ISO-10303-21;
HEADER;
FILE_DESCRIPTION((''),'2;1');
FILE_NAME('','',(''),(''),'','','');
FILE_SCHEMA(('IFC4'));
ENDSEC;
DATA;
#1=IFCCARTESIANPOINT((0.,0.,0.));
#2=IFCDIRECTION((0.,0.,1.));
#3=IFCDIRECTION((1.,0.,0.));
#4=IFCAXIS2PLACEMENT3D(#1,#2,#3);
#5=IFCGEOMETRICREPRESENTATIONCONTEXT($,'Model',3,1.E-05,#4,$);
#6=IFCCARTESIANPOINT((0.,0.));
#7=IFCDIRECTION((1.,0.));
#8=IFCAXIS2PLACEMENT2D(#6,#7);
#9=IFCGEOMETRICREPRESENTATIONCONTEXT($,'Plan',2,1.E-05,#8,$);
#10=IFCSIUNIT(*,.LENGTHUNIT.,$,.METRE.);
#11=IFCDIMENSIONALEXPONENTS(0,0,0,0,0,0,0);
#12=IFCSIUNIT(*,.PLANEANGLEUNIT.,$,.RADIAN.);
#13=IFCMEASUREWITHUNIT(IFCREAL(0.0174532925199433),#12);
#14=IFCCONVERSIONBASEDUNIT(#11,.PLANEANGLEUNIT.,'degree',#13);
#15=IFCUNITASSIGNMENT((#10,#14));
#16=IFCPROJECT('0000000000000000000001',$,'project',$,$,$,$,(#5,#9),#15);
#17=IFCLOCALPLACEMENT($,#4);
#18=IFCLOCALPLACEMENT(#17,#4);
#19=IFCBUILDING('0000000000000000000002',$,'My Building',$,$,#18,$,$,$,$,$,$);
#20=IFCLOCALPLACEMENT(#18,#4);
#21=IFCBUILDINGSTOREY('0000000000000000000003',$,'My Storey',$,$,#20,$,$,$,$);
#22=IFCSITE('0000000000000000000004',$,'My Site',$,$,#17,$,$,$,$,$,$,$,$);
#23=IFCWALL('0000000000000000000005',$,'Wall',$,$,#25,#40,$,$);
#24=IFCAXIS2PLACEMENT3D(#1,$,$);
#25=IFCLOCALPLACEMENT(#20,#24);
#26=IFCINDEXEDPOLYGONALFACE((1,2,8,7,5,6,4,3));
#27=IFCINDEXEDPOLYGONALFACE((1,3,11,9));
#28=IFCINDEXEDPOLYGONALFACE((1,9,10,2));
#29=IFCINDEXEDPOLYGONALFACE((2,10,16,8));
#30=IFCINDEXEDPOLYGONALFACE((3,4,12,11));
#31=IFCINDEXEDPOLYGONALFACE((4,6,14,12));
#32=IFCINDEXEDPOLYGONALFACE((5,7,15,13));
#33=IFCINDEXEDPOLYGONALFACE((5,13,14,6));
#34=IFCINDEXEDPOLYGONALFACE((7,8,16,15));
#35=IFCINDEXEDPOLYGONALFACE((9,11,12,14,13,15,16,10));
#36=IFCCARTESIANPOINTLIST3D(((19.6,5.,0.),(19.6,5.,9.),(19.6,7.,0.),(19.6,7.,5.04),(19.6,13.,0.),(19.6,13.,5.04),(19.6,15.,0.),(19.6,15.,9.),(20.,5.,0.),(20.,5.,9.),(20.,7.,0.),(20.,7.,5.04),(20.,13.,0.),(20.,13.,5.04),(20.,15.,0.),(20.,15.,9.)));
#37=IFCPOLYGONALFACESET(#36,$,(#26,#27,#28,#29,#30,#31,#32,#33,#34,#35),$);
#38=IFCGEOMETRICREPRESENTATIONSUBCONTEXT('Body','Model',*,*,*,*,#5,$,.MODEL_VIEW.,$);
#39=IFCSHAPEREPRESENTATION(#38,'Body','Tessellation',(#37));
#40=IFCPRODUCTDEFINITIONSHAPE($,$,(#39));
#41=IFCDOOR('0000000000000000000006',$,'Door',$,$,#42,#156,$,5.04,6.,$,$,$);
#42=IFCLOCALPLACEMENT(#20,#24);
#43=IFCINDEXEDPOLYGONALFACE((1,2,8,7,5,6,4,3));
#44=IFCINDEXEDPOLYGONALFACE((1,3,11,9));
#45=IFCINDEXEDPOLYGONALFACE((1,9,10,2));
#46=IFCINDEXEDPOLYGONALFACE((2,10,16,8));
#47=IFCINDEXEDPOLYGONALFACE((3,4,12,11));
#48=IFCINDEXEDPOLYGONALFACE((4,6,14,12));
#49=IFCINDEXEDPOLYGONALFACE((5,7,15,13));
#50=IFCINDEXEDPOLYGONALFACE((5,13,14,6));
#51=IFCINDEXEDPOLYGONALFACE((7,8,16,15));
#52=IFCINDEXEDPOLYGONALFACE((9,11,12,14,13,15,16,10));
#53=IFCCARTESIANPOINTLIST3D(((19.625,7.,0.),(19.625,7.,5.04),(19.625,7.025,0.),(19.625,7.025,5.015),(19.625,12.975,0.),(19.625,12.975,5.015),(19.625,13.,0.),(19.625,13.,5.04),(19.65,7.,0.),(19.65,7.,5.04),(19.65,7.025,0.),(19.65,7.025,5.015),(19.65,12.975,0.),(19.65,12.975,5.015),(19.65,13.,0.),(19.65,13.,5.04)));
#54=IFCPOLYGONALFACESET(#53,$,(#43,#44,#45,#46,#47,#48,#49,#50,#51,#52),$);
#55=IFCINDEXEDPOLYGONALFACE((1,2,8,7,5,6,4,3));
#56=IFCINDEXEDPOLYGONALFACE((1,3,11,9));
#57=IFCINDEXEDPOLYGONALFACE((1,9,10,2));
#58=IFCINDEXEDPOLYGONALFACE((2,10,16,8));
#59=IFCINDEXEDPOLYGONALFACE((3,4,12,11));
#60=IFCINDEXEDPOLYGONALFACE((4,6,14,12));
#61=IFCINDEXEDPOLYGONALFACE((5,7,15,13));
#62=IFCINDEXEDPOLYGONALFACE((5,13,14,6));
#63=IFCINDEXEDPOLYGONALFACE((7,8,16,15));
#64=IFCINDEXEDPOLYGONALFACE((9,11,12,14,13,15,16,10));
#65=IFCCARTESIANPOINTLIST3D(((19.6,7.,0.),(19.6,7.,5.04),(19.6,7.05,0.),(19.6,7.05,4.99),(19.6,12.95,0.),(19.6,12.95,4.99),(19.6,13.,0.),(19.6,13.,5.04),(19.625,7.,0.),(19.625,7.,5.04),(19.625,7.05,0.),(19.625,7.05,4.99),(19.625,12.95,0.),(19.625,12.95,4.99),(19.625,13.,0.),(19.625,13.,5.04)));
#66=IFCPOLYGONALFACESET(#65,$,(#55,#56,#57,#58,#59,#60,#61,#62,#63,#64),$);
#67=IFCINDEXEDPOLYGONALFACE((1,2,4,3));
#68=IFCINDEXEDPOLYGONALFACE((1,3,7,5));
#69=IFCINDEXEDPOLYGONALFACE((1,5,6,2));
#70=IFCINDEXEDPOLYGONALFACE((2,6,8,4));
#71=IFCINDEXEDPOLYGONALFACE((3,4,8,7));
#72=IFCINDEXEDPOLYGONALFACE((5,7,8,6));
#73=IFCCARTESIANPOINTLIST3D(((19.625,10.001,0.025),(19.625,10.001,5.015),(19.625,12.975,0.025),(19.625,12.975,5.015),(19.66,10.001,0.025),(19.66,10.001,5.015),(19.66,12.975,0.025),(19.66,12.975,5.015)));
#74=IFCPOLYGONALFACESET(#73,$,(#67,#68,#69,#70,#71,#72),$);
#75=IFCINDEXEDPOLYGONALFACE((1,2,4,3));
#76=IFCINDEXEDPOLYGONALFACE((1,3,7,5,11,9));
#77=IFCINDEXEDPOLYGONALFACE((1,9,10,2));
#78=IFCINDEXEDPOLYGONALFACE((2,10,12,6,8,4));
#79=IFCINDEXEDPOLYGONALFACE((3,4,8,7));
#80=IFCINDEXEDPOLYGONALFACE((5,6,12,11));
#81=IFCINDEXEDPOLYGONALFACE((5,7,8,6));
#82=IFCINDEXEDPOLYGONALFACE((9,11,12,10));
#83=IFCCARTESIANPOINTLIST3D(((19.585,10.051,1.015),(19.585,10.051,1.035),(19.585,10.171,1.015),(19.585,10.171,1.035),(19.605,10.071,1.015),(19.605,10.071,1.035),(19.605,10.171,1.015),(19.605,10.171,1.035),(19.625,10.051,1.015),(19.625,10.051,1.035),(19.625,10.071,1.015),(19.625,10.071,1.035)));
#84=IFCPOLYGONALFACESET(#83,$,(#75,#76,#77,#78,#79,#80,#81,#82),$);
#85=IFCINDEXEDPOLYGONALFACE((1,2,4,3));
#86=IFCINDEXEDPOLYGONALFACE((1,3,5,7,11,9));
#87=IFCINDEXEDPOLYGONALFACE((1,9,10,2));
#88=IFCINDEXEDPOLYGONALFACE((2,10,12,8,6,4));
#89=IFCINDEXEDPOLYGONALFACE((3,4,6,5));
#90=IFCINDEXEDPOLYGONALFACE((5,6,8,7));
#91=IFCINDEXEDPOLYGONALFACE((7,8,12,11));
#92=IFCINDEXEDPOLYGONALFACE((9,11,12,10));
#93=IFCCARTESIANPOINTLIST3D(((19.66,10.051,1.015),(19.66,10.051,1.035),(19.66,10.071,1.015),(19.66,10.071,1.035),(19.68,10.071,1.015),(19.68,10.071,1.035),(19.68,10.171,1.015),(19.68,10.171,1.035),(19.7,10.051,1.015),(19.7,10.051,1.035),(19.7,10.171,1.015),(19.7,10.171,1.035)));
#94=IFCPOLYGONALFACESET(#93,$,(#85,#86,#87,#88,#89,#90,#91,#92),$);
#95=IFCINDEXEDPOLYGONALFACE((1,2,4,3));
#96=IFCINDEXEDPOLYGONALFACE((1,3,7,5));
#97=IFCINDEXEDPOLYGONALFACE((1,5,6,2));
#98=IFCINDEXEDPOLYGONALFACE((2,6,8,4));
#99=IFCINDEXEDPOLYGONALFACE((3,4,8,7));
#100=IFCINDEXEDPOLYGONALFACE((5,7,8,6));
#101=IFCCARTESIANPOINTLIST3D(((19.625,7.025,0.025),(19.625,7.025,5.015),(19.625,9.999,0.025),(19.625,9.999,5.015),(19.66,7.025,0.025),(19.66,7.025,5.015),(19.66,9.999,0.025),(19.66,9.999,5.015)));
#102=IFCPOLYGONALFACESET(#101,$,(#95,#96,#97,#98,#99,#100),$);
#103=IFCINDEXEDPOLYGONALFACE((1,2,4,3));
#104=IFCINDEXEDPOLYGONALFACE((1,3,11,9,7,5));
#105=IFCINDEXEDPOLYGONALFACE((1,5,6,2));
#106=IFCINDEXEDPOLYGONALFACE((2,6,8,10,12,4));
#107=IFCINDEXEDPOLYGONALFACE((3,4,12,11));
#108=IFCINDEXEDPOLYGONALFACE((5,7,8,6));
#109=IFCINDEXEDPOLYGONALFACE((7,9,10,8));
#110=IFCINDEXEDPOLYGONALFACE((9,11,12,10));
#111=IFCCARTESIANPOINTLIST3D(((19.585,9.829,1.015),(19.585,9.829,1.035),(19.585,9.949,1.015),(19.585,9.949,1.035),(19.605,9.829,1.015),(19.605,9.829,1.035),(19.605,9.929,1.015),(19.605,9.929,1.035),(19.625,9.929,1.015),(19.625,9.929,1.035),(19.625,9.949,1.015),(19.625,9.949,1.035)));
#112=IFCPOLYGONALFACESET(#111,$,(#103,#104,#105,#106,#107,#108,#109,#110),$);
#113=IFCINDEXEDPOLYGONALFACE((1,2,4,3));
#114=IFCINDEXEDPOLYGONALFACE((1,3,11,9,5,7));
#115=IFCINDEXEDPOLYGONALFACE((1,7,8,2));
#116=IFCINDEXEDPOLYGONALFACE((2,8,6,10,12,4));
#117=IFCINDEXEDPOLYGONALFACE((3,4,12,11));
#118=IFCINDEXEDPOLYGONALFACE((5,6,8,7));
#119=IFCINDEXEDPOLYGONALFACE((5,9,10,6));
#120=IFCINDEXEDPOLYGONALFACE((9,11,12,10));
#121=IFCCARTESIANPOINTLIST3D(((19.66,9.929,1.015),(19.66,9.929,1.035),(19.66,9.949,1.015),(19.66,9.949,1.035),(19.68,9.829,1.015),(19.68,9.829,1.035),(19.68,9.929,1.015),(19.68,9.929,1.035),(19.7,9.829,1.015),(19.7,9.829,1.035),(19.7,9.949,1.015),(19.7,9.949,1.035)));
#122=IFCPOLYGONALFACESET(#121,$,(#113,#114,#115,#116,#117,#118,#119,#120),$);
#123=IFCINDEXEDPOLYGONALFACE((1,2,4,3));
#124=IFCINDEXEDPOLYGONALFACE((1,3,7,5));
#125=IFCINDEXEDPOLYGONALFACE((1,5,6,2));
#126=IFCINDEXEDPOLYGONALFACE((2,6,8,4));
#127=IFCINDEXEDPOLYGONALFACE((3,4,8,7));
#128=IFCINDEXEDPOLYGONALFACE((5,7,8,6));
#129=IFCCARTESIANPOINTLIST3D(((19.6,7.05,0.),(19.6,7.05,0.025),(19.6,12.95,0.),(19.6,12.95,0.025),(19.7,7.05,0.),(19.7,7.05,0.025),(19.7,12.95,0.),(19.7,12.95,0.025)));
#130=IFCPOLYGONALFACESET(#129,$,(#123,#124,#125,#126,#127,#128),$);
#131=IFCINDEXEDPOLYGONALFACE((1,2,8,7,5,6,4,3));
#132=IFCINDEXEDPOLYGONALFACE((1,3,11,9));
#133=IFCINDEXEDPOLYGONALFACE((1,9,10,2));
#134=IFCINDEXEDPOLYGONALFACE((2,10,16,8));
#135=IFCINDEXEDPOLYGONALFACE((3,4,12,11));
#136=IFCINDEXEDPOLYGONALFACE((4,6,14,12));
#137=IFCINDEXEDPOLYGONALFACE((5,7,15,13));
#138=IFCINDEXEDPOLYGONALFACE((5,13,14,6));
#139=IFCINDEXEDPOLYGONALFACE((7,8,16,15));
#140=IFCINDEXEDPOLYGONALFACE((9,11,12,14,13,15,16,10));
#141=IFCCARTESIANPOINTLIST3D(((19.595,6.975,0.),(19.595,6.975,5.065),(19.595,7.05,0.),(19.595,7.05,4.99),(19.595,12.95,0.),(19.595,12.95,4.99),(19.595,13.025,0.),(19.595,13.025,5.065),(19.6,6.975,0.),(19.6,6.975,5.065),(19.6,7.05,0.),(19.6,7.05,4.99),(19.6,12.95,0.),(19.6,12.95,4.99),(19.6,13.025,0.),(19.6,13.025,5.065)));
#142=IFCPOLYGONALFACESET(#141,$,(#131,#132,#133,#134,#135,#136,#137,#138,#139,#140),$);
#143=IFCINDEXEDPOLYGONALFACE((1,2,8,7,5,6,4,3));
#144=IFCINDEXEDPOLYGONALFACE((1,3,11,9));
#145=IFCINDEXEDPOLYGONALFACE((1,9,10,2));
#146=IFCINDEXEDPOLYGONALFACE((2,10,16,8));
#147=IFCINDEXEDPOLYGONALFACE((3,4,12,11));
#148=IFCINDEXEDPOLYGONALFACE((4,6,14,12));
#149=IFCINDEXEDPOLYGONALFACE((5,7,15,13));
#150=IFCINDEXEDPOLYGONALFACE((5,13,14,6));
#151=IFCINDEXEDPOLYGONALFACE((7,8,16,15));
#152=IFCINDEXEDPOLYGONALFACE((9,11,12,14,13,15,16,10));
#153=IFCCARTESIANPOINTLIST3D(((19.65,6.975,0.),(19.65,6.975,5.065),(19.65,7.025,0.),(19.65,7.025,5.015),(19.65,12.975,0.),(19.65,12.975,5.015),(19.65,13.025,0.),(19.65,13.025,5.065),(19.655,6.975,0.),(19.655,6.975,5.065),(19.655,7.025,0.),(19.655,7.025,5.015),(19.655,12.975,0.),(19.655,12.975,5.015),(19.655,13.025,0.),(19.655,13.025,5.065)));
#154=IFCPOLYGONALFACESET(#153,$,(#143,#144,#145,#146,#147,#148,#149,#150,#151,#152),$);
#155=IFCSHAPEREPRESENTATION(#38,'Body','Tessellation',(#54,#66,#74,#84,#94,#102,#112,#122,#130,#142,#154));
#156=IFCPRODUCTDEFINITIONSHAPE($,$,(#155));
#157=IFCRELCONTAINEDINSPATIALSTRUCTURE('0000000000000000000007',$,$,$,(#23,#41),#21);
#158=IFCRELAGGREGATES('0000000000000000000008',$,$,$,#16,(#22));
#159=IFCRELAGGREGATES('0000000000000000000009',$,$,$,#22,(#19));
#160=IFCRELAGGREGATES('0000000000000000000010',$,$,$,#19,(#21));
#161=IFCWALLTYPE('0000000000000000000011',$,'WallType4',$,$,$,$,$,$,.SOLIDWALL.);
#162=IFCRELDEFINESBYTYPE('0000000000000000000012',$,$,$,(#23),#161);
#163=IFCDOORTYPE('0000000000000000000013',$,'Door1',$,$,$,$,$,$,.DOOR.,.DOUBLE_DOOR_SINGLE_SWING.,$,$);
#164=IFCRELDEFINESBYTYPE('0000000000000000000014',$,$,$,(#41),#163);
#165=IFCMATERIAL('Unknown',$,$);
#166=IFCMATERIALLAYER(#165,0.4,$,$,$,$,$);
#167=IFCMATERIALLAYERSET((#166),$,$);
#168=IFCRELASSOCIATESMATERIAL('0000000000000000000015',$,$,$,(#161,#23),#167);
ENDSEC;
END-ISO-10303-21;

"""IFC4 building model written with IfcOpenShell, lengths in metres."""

from ifc_helpers import new_model, entity, si_unit, converted_unit, frame, origin_with_axes, origin_2d_with_axis, place, context, subcontext, project, spatial, line, indexed_curve, outline, extrude, shape, source, transform, mapped, material, layer, layer_set, layer_usage, type_object, type_shapes, element, fill, save


model = new_model("IFC4")

# Units and contexts
model_context = context("Model", 3, precision=1e-05, world=origin_with_axes())
plan_context = context("Plan", 2, precision=1e-05, world=origin_2d_with_axis())
body_context_1 = subcontext(model_context, "Body", "Model", "MODEL_VIEW")
body_context_2 = subcontext(plan_context, "Body", "Plan", "PLAN_VIEW")
ifc_project = project(units=[si_unit("LENGTHUNIT", "METRE"), converted_unit("PLANEANGLEUNIT", "degree", entity("IfcReal", 0.0174532925199433), si_unit("PLANEANGLEUNIT", "RADIAN"), dimensions=[0, 0, 0, 0, 0, 0, 0])], contexts=[model_context, plan_context])

# Site, building, storey
site_placement = place(None, origin_with_axes())
site = spatial("IfcSite", under=ifc_project, at=site_placement, Name="My Site")
building_placement = place(site_placement, origin_with_axes())
building = spatial("IfcBuilding", under=site, at=building_placement, Name="My Building")
storey_placement = place(building_placement, origin_with_axes())
storey = spatial("IfcBuildingStorey", under=building, at=storey_placement, Name="My Storey")

# Shared definitions
ifc_material = material(Name="Unknown")

# Wall, opening, door
ifc_layer_1 = layer(ifc_material, 0.4)
ifc_layer_set_1 = layer_set([ifc_layer_1])
wall_type_1 = type_object("IfcWallType", Name="WallType4", PredefinedType="SOLIDWALL", material=ifc_layer_set_1)
ifc_layer_usage_1 = layer_usage(ifc_layer_set_1, "AXIS2", "POSITIVE", 0.0)
wall_1_placement = place(storey_placement, frame((19.6, 15.0, 0.0), z_axis=(0.0, 0.0, 1.0), x_axis=(0.0, -1.0, 0.0)))
wall_1 = element("IfcWall", 1, at=wall_1_placement, inside=storey, type_object=wall_type_1, material=ifc_layer_usage_1, Name="Wall", context=body_context_1, shape_type="SweptSolid", body=[
    extrude(outline(indexed_curve([(0.0, 0.0), (0.0, 0.4), (10.0, 0.4), (10.0, 0.0), (0.0, 0.0)], self_intersect=False)), origin_with_axes(), (0.0, 0.0, 1.0), 9.0),
])
shared_shape_1 = source(origin_with_axes(), body_context_1, "Body", "SweptSolid", [
    extrude(outline(indexed_curve([(0.0, 0.0), (6.0, 0.0), (6.0, 5.04), (0.0, 5.04)], segments=[line(1, 2, 3, 4, 1)])), frame((0.0, -0.1, 0.0), z_axis=(0.0, -1.0, 0.0), x_axis=(1.0, 0.0, 0.0)), (0.0, 0.0, -1.0), 0.6),
])
opening_1_placement = place(wall_1_placement, frame((2.0, 0.0, 0.0), z_axis=(0.0, 0.0, 1.0), x_axis=(1.0, 0.0, 0.0)))
opening_1 = element("IfcOpeningElement", 2, at=opening_1_placement, cuts=wall_1, PredefinedType="OPENING", context=body_context_1, shape_type="MappedRepresentation", body=[
    mapped(shared_shape_1, transform((0.0, 0.0, 0.0), x_axis=(1.0, 0.0, 0.0), y_axis=(0.0, 1.0, 0.0), z_axis=(0.0, 0.0, 1.0), scale=1.0)),
])
door_type_1 = type_object("IfcDoorType", Name="Door1", OperationType="DOUBLE_DOOR_SINGLE_SWING", PredefinedType="DOOR")
shared_shape_2 = source(origin_with_axes(), body_context_1, "Body", "SweptSolid", [
    extrude(outline(indexed_curve([(0.0, 0.0), (0.0, 5.04), (6.0, 5.04), (6.0, 0.0), (5.975, 0.0), (5.975, 5.015), (0.025, 5.015), (0.025, 0.0)], segments=[line(1, 2, 3, 4, 5, 6, 7, 8, 1)])), frame((0.0, 0.025, 0.0), z_axis=(0.0, -1.0, 0.0), x_axis=(1.0, 0.0, 0.0)), (0.0, 0.0, -1.0), 0.025),
    extrude(outline(indexed_curve([(0.0, 0.0), (0.0, 5.04), (6.0, 5.04), (6.0, 0.0), (5.95, 0.0), (5.95, 4.99), (0.05, 4.99), (0.05, 0.0)], segments=[line(1, 2, 3, 4, 5, 6, 7, 8, 1)])), frame((0.0, 0.0, 0.0), z_axis=(0.0, -1.0, 0.0), x_axis=(1.0, 0.0, 0.0)), (0.0, 0.0, -1.0), 0.025),
    extrude(outline(indexed_curve([(0.0, 0.0), (2.974, 0.0), (2.974, 0.035), (0.0, 0.035)], segments=[line(1, 2, 3, 4, 1)])), frame((0.025, 0.025, 0.025), z_axis=(0.0, 0.0, 1.0), x_axis=(1.0, 0.0, 0.0)), (0.0, 0.0, 1.0), 4.99),
    extrude(outline(indexed_curve([(0.0, 0.0), (0.0, -0.04), (-0.12, -0.04), (-0.12, -0.02), (-0.02, -0.02), (-0.02, 0.0)], segments=[line(1, 2, 3, 4, 5, 6, 1)])), frame((2.949, 0.025, 1.015), z_axis=(0.0, 0.0, 1.0), x_axis=(1.0, 0.0, 0.0)), (0.0, 0.0, 1.0), 0.02),
    extrude(outline(indexed_curve([(0.0, 0.0), (0.0, 0.04), (-0.12, 0.04), (-0.12, 0.02), (-0.02, 0.02), (-0.02, 0.0)], segments=[line(1, 2, 3, 4, 5, 6, 1)])), frame((2.949, 0.06, 1.015), z_axis=(0.0, 0.0, 1.0), x_axis=(1.0, 0.0, 0.0)), (0.0, 0.0, 1.0), 0.02),
    extrude(outline(indexed_curve([(0.0, 0.0), (-2.974, 0.0), (-2.974, 0.035), (0.0, 0.035)], segments=[line(1, 2, 3, 4, 1)])), frame((5.975, 0.025, 0.025), z_axis=(0.0, 0.0, 1.0), x_axis=(1.0, 0.0, 0.0)), (0.0, 0.0, 1.0), 4.99),
    extrude(outline(indexed_curve([(0.0, 0.0), (0.0, -0.04), (0.12, -0.04), (0.12, -0.02), (0.02, -0.02), (0.02, 0.0)], segments=[line(1, 2, 3, 4, 5, 6, 1)])), frame((3.051, 0.025, 1.015), z_axis=(0.0, 0.0, 1.0), x_axis=(1.0, 0.0, 0.0)), (0.0, 0.0, 1.0), 0.02),
    extrude(outline(indexed_curve([(0.0, 0.0), (0.0, 0.04), (0.12, 0.04), (0.12, 0.02), (0.02, 0.02), (0.02, 0.0)], segments=[line(1, 2, 3, 4, 5, 6, 1)])), frame((3.051, 0.06, 1.015), z_axis=(0.0, 0.0, 1.0), x_axis=(1.0, 0.0, 0.0)), (0.0, 0.0, 1.0), 0.02),
    extrude(outline(indexed_curve([(0.0, 0.0), (5.9, 0.0), (5.9, 0.1), (0.0, 0.1)], segments=[line(1, 2, 3, 4, 1)])), frame((0.05, 0.0, 0.0), z_axis=(0.0, 0.0, 1.0), x_axis=(1.0, 0.0, 0.0)), (0.0, 0.0, 1.0), 0.025),
    extrude(outline(indexed_curve([(0.0, 0.0), (0.0, 5.065), (6.05, 5.065), (6.05, 0.0), (5.975, 0.0), (5.975, 4.99), (0.075, 4.99), (0.075, 0.0)], segments=[line(1, 2, 3, 4, 5, 6, 7, 8, 1)])), frame((-0.025, -0.005, 0.0), z_axis=(0.0, -1.0, 0.0), x_axis=(1.0, 0.0, 0.0)), (0.0, 0.0, -1.0), 0.005),
    extrude(outline(indexed_curve([(0.0, 0.0), (0.0, 5.065), (6.05, 5.065), (6.05, 0.0), (6.0, 0.0), (6.0, 5.015), (0.05, 5.015), (0.05, 0.0)], segments=[line(1, 2, 3, 4, 5, 6, 7, 8, 1)])), frame((-0.025, 0.05, 0.0), z_axis=(0.0, -1.0, 0.0), x_axis=(1.0, 0.0, 0.0)), (0.0, 0.0, -1.0), 0.005),
])
shared_shape_3 = source(origin_with_axes(), body_context_2, "Body", "Curve2D", [
    entity("IfcIndexedPolyCurve", entity("IfcCartesianPointList2D", [[0.0, 0.0], [0.0, 0.05], [0.025, 0.05], [0.025, 0.025], [0.05, 0.025], [0.05, 0.0]]), [entity("IfcLineIndex", [1, 2, 3, 4, 5, 6, 1])]),
    entity("IfcIndexedPolyCurve", entity("IfcCartesianPointList2D", [[6.0, 0.0], [6.0, 0.05], [5.975, 0.05], [5.975, 0.025], [5.95, 0.025], [5.95, 0.0]]), [entity("IfcLineIndex", [1, 2, 3, 4, 5, 6, 1])]),
    entity("IfcTrimmedCurve", entity("IfcEllipse", entity("IfcAxis2Placement2D", entity("IfcCartesianPoint", [0.06, 0.05]), entity("IfcDirection", [1.0, 0.0])), 2.94, 2.975), [entity("IfcCartesianPoint", [3.0, 0.05])], [entity("IfcCartesianPoint", [0.06, 3.025])], True, "CARTESIAN"),
    entity("IfcIndexedPolyCurve", entity("IfcCartesianPointList2D", [[0.025, 0.05], [0.06, 0.05], [0.06, 3.025], [0.025, 3.025]]), [entity("IfcLineIndex", [1, 2, 3, 4, 1])]),
    entity("IfcTrimmedCurve", entity("IfcEllipse", entity("IfcAxis2Placement2D", entity("IfcCartesianPoint", [5.94, 0.05]), entity("IfcDirection", [1.0, 0.0])), 2.94, 2.975), [entity("IfcCartesianPoint", [5.94, 3.025])], [entity("IfcCartesianPoint", [3.0, 0.05])], True, "CARTESIAN"),
    entity("IfcIndexedPolyCurve", entity("IfcCartesianPointList2D", [[5.975, 0.05], [5.94, 0.05], [5.94, 3.025], [5.975, 3.025]]), [entity("IfcLineIndex", [1, 2, 3, 4, 1])]),
])
type_shapes(door_type_1, [shared_shape_2, shared_shape_3])
door_1_placement = place(opening_1_placement, frame((0.0, 0.0, 0.0), z_axis=(0.0, 0.0, 1.0), x_axis=(1.0, 0.0, 0.0)))
door_1 = element("IfcDoor", 3, at=door_1_placement, inside=storey, type_object=door_type_1, Name="Door", OverallHeight=5.04, OverallWidth=6.0, shapes=[
    shape(body_context_1, "Body", "MappedRepresentation", [mapped(shared_shape_2, transform((0.0, 0.0, 0.0), x_axis=(1.0, 0.0, 0.0), y_axis=(0.0, 1.0, 0.0), z_axis=(0.0, 0.0, 1.0), scale=1.0))]),
    shape(body_context_2, "Body", "MappedRepresentation", [mapped(shared_shape_3, transform((0.0, 0.0, 0.0), x_axis=(1.0, 0.0, 0.0), y_axis=(0.0, 1.0, 0.0), z_axis=(0.0, 0.0, 1.0), scale=1.0))]),
])
fill(opening_1, door_1)

save(model, "model.ifc")
